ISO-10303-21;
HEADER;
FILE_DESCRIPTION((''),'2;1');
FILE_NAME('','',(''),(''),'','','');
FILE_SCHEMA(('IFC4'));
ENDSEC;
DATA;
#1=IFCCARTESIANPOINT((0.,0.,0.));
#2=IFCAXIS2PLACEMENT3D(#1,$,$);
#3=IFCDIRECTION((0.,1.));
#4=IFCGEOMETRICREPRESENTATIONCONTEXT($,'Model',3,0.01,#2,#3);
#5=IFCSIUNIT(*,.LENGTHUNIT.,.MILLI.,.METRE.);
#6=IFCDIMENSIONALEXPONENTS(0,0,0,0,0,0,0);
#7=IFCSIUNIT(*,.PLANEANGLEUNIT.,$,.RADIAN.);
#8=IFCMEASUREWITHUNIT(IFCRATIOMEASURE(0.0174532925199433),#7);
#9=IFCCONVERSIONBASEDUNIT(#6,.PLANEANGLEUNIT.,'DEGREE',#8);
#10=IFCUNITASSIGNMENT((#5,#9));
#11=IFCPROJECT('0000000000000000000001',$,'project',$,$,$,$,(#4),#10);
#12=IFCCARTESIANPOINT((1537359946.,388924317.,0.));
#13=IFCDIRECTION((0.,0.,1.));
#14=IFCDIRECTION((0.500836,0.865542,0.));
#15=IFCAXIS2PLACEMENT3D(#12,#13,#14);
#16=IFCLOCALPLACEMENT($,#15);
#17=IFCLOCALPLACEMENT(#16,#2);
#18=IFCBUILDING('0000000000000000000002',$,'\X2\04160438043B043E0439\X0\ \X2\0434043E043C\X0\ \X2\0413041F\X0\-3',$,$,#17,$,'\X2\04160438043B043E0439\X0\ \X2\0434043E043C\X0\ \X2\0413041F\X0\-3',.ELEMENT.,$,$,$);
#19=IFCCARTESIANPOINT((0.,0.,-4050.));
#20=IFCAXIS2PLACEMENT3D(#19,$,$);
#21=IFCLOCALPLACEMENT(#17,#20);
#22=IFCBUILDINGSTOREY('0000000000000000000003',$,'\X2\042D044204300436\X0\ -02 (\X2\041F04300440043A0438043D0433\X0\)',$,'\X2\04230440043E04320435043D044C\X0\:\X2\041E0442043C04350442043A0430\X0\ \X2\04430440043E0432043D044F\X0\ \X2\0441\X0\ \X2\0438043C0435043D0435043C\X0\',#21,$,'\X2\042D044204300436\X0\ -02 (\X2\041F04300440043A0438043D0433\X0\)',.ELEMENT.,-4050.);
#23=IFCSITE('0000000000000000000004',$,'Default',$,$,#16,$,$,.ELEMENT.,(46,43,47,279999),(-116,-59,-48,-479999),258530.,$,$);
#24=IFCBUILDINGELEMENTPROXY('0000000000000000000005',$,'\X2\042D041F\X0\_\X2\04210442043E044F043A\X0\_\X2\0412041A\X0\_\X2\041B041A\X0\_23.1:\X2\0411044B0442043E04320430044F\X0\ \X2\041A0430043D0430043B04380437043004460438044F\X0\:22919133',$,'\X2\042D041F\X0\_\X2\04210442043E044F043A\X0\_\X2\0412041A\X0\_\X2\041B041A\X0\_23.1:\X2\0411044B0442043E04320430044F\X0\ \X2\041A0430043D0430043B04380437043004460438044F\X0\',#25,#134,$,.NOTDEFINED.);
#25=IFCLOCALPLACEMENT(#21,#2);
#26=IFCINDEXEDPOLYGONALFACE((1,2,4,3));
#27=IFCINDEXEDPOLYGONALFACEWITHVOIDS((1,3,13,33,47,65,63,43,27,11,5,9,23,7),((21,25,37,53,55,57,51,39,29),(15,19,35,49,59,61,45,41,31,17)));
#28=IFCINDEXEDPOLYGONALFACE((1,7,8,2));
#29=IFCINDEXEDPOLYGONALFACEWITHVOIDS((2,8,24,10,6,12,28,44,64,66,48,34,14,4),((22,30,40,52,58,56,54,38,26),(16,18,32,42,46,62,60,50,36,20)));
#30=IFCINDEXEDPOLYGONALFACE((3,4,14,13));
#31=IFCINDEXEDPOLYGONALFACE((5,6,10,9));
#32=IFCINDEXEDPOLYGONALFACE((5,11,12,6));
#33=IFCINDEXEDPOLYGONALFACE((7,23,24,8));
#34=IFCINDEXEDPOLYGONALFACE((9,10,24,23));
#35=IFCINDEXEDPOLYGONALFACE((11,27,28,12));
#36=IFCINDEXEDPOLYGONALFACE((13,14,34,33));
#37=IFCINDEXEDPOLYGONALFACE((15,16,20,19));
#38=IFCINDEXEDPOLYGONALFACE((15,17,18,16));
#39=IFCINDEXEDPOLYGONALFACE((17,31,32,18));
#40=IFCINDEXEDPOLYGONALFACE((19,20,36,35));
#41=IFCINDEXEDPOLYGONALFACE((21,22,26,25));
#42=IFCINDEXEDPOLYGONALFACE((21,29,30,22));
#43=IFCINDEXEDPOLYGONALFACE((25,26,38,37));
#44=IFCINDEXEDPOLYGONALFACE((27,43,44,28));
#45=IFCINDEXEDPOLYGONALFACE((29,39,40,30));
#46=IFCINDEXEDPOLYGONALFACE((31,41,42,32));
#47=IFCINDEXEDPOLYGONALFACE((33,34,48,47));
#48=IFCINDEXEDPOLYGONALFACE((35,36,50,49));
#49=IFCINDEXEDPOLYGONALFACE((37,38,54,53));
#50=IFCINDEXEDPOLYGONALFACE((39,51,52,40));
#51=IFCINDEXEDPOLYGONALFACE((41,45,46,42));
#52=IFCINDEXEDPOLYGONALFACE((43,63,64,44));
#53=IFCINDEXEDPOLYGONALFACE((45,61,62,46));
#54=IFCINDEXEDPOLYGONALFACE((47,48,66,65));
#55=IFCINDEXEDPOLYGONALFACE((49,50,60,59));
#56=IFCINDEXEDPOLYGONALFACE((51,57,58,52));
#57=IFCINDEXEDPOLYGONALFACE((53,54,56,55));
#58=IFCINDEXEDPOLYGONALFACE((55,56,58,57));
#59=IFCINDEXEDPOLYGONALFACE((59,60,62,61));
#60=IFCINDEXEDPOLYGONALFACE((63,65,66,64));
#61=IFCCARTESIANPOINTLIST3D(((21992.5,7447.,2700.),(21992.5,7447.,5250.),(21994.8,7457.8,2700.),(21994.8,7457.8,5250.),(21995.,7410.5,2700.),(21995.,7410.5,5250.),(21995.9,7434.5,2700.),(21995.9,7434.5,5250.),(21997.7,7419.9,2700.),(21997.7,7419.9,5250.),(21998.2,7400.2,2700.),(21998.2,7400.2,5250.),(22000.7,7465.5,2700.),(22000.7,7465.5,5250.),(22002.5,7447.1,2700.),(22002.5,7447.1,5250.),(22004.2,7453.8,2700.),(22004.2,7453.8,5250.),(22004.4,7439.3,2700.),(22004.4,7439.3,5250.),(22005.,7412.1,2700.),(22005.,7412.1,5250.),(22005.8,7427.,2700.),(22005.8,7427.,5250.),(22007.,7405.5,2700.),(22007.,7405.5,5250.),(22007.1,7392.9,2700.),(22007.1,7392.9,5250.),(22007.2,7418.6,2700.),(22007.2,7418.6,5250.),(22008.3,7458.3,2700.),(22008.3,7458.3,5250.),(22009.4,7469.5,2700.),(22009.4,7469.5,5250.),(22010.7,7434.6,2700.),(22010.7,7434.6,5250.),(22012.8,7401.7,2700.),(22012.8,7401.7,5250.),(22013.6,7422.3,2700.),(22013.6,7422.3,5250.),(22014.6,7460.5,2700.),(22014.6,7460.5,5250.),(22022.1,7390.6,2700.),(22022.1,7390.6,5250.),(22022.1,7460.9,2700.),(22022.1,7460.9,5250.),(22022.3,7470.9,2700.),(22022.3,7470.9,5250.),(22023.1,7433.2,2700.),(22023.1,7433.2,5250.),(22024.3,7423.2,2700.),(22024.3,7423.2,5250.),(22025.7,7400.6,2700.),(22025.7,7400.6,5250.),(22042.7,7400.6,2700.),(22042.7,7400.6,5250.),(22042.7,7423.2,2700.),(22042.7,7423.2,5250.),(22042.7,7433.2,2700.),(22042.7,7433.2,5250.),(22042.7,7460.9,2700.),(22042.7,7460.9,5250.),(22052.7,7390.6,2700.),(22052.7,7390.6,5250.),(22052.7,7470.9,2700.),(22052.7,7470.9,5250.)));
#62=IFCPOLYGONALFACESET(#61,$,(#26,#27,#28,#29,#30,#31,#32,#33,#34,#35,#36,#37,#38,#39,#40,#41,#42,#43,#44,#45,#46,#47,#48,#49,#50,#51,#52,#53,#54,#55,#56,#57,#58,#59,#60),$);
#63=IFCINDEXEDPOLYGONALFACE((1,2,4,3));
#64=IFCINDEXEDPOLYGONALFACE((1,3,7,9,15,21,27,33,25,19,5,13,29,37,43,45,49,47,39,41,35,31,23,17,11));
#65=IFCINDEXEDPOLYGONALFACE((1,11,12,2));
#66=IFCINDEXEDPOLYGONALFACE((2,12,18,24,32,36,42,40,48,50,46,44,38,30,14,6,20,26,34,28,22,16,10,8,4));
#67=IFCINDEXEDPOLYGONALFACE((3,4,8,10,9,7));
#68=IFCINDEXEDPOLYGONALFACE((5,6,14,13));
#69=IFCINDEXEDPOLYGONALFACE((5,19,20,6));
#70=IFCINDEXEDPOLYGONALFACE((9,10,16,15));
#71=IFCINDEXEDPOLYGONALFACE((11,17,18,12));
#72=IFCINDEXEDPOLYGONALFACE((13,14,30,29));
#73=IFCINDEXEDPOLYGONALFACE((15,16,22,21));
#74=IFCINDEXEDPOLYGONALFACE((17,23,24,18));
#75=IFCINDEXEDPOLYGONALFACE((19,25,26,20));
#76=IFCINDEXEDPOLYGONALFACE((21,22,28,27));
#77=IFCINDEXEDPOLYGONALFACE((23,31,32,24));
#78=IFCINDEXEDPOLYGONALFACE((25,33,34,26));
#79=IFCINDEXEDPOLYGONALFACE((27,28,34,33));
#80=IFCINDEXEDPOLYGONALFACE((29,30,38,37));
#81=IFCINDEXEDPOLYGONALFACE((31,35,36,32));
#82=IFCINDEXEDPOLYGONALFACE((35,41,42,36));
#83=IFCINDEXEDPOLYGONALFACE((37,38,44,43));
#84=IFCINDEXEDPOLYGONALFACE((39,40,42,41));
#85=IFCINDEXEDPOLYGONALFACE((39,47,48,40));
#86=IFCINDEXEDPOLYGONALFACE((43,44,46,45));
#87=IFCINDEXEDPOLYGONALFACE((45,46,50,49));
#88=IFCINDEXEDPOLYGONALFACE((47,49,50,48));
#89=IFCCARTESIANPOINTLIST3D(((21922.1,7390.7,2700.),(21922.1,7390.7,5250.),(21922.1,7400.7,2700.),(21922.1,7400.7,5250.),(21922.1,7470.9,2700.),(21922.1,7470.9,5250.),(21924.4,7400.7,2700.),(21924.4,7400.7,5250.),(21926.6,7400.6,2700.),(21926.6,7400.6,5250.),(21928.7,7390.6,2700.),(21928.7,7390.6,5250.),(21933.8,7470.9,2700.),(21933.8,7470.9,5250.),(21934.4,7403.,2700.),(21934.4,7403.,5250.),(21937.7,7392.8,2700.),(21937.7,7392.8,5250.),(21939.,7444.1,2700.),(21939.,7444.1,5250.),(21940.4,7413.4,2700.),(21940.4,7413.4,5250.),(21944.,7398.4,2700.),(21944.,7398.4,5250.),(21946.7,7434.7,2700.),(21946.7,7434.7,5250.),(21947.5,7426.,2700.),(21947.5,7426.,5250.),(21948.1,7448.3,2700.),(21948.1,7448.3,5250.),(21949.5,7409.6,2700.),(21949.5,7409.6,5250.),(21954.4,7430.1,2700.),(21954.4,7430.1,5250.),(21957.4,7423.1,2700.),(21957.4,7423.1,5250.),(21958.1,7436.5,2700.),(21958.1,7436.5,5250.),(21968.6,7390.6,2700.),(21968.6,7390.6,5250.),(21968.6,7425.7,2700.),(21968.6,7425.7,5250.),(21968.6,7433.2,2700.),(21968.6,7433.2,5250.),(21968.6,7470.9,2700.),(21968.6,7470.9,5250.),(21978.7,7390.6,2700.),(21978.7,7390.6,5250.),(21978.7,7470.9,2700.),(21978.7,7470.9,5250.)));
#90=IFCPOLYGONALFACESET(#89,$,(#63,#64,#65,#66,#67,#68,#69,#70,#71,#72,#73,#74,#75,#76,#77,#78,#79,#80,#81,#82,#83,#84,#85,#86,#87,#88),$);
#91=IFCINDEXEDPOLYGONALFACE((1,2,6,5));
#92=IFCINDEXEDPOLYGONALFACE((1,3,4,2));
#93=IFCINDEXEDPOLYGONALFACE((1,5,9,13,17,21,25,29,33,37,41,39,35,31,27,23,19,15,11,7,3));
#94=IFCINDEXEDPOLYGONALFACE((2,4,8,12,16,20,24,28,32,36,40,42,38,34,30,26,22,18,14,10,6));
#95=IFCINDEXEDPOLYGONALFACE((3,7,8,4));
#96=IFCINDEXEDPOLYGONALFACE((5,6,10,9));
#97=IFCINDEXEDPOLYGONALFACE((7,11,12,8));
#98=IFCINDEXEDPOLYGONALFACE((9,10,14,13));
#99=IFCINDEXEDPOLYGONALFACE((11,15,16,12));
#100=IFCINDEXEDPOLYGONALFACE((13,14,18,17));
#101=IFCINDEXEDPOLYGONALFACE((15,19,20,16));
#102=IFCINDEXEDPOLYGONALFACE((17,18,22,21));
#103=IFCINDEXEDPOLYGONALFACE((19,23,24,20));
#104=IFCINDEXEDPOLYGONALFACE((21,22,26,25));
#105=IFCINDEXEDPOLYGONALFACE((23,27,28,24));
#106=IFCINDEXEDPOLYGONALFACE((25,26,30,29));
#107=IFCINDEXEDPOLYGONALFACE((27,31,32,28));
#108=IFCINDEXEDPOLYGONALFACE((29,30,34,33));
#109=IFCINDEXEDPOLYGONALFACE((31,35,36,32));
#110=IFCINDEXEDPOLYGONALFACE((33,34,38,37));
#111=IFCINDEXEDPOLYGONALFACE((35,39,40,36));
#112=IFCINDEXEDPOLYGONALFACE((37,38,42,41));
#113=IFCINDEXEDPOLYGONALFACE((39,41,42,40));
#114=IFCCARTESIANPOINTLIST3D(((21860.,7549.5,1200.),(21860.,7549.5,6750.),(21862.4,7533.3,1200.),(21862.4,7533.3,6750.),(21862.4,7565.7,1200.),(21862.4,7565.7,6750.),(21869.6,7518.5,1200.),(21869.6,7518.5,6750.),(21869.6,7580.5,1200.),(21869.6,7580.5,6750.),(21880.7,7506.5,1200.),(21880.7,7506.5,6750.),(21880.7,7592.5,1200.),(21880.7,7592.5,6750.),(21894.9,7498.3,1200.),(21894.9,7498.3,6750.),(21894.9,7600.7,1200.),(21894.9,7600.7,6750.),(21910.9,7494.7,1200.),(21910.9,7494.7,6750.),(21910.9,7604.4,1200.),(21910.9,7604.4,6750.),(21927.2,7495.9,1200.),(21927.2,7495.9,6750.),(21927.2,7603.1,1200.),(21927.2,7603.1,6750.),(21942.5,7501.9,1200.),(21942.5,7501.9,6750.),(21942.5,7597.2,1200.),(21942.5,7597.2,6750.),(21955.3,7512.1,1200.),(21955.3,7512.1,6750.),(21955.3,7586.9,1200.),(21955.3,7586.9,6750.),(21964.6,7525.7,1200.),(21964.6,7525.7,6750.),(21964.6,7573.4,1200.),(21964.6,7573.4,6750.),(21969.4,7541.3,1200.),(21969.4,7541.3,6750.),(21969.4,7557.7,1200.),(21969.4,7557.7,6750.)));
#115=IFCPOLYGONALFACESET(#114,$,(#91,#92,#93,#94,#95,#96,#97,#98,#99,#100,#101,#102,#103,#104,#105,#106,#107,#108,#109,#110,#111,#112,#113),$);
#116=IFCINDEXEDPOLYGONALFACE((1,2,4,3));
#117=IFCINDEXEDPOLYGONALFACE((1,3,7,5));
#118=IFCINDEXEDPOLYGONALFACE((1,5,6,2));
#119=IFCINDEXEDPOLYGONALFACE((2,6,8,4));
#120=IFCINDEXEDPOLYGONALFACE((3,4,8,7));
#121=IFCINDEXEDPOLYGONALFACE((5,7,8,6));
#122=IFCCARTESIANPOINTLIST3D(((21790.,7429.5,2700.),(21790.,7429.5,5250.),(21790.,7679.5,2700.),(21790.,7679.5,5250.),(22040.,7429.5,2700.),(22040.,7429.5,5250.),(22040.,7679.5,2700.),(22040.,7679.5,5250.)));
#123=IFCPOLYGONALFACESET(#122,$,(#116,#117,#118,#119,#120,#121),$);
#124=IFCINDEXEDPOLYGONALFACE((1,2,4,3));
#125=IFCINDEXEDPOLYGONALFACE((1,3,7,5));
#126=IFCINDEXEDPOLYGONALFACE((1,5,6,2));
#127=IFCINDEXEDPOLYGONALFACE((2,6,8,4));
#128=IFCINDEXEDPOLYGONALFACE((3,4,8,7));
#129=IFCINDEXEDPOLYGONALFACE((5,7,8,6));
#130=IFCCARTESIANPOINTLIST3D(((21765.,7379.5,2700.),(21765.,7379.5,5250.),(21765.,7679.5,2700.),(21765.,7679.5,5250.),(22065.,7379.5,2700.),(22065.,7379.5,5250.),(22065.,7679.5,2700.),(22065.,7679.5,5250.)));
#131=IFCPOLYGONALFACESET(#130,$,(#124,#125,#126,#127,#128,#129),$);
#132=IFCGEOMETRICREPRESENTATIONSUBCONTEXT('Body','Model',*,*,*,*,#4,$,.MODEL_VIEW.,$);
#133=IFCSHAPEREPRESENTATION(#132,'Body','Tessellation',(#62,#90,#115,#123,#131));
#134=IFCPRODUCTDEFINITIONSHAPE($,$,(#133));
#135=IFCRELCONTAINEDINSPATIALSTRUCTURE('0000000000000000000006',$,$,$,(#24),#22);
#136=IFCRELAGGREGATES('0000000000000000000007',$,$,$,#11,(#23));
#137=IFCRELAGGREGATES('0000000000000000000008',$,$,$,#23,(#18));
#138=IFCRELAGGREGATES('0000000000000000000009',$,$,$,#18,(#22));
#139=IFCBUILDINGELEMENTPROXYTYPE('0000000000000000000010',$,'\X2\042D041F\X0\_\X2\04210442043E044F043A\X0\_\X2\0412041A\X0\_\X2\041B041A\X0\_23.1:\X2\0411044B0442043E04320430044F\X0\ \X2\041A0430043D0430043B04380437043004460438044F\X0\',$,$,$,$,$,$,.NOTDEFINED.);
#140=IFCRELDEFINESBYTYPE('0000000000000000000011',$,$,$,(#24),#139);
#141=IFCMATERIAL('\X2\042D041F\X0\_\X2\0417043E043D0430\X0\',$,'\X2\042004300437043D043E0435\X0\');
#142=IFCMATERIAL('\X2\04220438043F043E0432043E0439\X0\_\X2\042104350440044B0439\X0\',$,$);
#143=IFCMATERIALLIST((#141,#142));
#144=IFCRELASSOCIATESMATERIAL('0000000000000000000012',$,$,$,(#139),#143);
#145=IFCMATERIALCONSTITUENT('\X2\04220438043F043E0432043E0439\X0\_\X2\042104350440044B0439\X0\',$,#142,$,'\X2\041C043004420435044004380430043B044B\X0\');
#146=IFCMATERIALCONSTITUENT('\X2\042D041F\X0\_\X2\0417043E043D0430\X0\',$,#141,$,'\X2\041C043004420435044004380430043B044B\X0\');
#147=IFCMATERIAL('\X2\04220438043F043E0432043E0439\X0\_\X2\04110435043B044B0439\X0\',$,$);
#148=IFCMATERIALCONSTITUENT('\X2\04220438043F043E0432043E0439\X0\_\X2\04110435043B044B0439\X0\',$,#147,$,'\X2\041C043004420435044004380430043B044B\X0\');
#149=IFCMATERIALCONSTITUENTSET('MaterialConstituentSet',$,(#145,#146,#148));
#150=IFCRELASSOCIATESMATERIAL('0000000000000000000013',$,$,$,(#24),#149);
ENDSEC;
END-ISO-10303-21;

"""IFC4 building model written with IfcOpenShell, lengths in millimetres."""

from ifc_helpers import new_model, entity, si_unit, converted_unit, direction, frame, frame_2d, origin, place, context, subcontext, project, spatial, polyline, rectangle, circle, outline, extrude, source, transform, mapped, material, material_list, constituent, constituent_set, type_object, type_shapes, element, save


model = new_model("IFC4")

# Units and contexts
model_context = context("Model", 3, precision=0.01, world=origin(), true_north=direction((0.0, 1.0)))
body_context = subcontext(model_context, "Body", "Model", "MODEL_VIEW")
ifc_project = project(units=[si_unit("LENGTHUNIT", "METRE", prefix="MILLI"), converted_unit("PLANEANGLEUNIT", "DEGREE", entity("IfcRatioMeasure", 0.0174532925199433), si_unit("PLANEANGLEUNIT", "RADIAN"), dimensions=[0, 0, 0, 0, 0, 0, 0])], contexts=[model_context])

# Site, building, storey
site_placement = place(None, frame((1537359946.0, 388924317.0, 0.0), z_axis=(0.0, 0.0, 1.0), x_axis=(0.500836, 0.865542, 0.0)))
site = spatial("IfcSite", under=ifc_project, at=site_placement, Name="Default", CompositionType="ELEMENT", RefLatitude=(46, 43, 47, 279999), RefLongitude=(-116, -59, -48, -479999), RefElevation=258530.0)
building_placement = place(site_placement, origin())
building = spatial("IfcBuilding", under=site, at=building_placement, Name="Жилой дом ГП-3", LongName="Жилой дом ГП-3", CompositionType="ELEMENT")
storey_placement = place(building_placement, frame((0.0, 0.0, -4050.0)))
storey = spatial("IfcBuildingStorey", under=building, at=storey_placement, Name="Этаж -02 (Паркинг)", ObjectType="Уровень:Отметка уровня с именем", LongName="Этаж -02 (Паркинг)", CompositionType="ELEMENT", Elevation=-4050.0)

# Shared definitions
ifc_material_1 = material(Name="ЭП_Зона", Category="Разное")
ifc_material_2 = material(Name="Типовой_Белый")
ifc_material_3 = material(Name="Типовой_Серый")

# Building element proxy
ifc_constituent_1 = constituent(ifc_material_3, Name="Типовой_Серый", Category="Материалы")
ifc_constituent_2 = constituent(ifc_material_1, Name="ЭП_Зона", Category="Материалы")
ifc_constituent_3 = constituent(ifc_material_2, Name="Типовой_Белый", Category="Материалы")
ifc_constituent_set_1 = constituent_set(constituents=[ifc_constituent_1, ifc_constituent_2, ifc_constituent_3], Name="MaterialConstituentSet")
ifc_material_list_1 = material_list([ifc_material_1, ifc_material_3])
building_element_proxy_type_1 = type_object("IfcBuildingElementProxyType", Name="ЭП_Стояк_ВК_ЛК_23.1:Бытовая Канализация", PredefinedType="NOTDEFINED", material=ifc_material_list_1)
shared_shape_1 = source(origin(), body_context, "Body", "SweptSolid", [
    extrude(outline(polyline([(-42.2, -39.0), (-11.8, -39.0), (1.1, -37.6), (9.8, -33.5), (15.7, -25.8), (18.0, -15.0), (14.6, -2.5), (4.7, 5.0), (12.8, 12.1), (15.5, 21.5), (12.3, 31.8), (3.4, 39.0), (-11.6, 41.4), (-42.2, 41.4), (-42.2, -39.0)]), holes=[polyline([(-32.2, 8.8), (-32.2, 31.4), (-15.2, 31.4), (-2.3, 30.3), (3.5, 26.4), (5.5, 19.9), (3.3, 13.3), (-3.1, 9.6), (-13.9, 8.8), (-32.2, 8.8)]), polyline([(-32.2, -28.9), (-32.2, -1.3), (-12.6, -1.3), (-0.2, -2.6), (6.1, -7.3), (8.0, -15.1), (6.3, -21.9), (2.2, -26.3), (-4.1, -28.5), (-11.6, -28.9), (-32.2, -28.9)])]), frame((54.5, -52.4, -1350.0)), (0.0, 0.0, 1.0), 2550.0),
    extrude(outline(polyline([(-32.1, -31.9), (48.3, -31.9), (48.3, -21.8), (10.6, -21.8), (13.8, -11.4), (25.6, -1.3), (48.3, 13.0), (48.3, 24.6), (21.4, 7.7), (12.0, 0.1), (7.4, -7.7), (3.3, -0.7), (-9.3, 6.4), (-19.7, 12.3), (-22.1, 20.2), (-22.0, 22.4), (-22.0, 24.6), (-32.0, 24.6), (-32.1, 18.0), (-29.9, 9.0), (-24.3, 2.8), (-13.1, -2.8), (0.4, -10.6), (3.0, -21.8), (-32.1, -21.8), (-32.1, -31.9)])), frame((118.2, -43.1, -1350.0), z_axis=(0.0, 0.0, 1.0), x_axis=(0.0, -1.0, 0.0)), (0.0, 0.0, 1.0), 2550.0),
    extrude(circle(Radius=55.0, at=frame_2d((0.0, 0.0), x_axis=(1.0, 0.0))), frame((150.0, -170.0, -2850.0)), (0.0, 0.0, 1.0), 5550.0),
    extrude(rectangle(XDim=250.0, YDim=250.0, at=frame_2d((0.0, 0.0), x_axis=(1.0, 0.0))), frame((150.0, -175.0, -1350.0)), (0.0, 0.0, 1.0), 2550.0),
    extrude(rectangle(XDim=300.0, YDim=300.0, at=frame_2d((0.0, 0.0), x_axis=(1.0, 0.0))), frame((150.0, -150.0, -1350.0)), (0.0, 0.0, 1.0), 2550.0),
])
type_shapes(building_element_proxy_type_1, [shared_shape_1])
proxy_1_placement = place(storey_placement, frame((22065.0, 7379.5, 4050.0), z_axis=(0.0, 0.0, 1.0), x_axis=(-1.0, 0.0, 0.0)))
element("IfcBuildingElementProxy", 1, at=proxy_1_placement, inside=storey, type_object=building_element_proxy_type_1, material=ifc_constituent_set_1, Name="ЭП_Стояк_ВК_ЛК_23.1:Бытовая Канализация:22919133", ObjectType="ЭП_Стояк_ВК_ЛК_23.1:Бытовая Канализация", PredefinedType="NOTDEFINED", context=body_context, shape_type="MappedRepresentation", body=[
    mapped(shared_shape_1, transform((0.0, 0.0, 0.0), scale=1.0)),
])

save(model, "model.ifc")
